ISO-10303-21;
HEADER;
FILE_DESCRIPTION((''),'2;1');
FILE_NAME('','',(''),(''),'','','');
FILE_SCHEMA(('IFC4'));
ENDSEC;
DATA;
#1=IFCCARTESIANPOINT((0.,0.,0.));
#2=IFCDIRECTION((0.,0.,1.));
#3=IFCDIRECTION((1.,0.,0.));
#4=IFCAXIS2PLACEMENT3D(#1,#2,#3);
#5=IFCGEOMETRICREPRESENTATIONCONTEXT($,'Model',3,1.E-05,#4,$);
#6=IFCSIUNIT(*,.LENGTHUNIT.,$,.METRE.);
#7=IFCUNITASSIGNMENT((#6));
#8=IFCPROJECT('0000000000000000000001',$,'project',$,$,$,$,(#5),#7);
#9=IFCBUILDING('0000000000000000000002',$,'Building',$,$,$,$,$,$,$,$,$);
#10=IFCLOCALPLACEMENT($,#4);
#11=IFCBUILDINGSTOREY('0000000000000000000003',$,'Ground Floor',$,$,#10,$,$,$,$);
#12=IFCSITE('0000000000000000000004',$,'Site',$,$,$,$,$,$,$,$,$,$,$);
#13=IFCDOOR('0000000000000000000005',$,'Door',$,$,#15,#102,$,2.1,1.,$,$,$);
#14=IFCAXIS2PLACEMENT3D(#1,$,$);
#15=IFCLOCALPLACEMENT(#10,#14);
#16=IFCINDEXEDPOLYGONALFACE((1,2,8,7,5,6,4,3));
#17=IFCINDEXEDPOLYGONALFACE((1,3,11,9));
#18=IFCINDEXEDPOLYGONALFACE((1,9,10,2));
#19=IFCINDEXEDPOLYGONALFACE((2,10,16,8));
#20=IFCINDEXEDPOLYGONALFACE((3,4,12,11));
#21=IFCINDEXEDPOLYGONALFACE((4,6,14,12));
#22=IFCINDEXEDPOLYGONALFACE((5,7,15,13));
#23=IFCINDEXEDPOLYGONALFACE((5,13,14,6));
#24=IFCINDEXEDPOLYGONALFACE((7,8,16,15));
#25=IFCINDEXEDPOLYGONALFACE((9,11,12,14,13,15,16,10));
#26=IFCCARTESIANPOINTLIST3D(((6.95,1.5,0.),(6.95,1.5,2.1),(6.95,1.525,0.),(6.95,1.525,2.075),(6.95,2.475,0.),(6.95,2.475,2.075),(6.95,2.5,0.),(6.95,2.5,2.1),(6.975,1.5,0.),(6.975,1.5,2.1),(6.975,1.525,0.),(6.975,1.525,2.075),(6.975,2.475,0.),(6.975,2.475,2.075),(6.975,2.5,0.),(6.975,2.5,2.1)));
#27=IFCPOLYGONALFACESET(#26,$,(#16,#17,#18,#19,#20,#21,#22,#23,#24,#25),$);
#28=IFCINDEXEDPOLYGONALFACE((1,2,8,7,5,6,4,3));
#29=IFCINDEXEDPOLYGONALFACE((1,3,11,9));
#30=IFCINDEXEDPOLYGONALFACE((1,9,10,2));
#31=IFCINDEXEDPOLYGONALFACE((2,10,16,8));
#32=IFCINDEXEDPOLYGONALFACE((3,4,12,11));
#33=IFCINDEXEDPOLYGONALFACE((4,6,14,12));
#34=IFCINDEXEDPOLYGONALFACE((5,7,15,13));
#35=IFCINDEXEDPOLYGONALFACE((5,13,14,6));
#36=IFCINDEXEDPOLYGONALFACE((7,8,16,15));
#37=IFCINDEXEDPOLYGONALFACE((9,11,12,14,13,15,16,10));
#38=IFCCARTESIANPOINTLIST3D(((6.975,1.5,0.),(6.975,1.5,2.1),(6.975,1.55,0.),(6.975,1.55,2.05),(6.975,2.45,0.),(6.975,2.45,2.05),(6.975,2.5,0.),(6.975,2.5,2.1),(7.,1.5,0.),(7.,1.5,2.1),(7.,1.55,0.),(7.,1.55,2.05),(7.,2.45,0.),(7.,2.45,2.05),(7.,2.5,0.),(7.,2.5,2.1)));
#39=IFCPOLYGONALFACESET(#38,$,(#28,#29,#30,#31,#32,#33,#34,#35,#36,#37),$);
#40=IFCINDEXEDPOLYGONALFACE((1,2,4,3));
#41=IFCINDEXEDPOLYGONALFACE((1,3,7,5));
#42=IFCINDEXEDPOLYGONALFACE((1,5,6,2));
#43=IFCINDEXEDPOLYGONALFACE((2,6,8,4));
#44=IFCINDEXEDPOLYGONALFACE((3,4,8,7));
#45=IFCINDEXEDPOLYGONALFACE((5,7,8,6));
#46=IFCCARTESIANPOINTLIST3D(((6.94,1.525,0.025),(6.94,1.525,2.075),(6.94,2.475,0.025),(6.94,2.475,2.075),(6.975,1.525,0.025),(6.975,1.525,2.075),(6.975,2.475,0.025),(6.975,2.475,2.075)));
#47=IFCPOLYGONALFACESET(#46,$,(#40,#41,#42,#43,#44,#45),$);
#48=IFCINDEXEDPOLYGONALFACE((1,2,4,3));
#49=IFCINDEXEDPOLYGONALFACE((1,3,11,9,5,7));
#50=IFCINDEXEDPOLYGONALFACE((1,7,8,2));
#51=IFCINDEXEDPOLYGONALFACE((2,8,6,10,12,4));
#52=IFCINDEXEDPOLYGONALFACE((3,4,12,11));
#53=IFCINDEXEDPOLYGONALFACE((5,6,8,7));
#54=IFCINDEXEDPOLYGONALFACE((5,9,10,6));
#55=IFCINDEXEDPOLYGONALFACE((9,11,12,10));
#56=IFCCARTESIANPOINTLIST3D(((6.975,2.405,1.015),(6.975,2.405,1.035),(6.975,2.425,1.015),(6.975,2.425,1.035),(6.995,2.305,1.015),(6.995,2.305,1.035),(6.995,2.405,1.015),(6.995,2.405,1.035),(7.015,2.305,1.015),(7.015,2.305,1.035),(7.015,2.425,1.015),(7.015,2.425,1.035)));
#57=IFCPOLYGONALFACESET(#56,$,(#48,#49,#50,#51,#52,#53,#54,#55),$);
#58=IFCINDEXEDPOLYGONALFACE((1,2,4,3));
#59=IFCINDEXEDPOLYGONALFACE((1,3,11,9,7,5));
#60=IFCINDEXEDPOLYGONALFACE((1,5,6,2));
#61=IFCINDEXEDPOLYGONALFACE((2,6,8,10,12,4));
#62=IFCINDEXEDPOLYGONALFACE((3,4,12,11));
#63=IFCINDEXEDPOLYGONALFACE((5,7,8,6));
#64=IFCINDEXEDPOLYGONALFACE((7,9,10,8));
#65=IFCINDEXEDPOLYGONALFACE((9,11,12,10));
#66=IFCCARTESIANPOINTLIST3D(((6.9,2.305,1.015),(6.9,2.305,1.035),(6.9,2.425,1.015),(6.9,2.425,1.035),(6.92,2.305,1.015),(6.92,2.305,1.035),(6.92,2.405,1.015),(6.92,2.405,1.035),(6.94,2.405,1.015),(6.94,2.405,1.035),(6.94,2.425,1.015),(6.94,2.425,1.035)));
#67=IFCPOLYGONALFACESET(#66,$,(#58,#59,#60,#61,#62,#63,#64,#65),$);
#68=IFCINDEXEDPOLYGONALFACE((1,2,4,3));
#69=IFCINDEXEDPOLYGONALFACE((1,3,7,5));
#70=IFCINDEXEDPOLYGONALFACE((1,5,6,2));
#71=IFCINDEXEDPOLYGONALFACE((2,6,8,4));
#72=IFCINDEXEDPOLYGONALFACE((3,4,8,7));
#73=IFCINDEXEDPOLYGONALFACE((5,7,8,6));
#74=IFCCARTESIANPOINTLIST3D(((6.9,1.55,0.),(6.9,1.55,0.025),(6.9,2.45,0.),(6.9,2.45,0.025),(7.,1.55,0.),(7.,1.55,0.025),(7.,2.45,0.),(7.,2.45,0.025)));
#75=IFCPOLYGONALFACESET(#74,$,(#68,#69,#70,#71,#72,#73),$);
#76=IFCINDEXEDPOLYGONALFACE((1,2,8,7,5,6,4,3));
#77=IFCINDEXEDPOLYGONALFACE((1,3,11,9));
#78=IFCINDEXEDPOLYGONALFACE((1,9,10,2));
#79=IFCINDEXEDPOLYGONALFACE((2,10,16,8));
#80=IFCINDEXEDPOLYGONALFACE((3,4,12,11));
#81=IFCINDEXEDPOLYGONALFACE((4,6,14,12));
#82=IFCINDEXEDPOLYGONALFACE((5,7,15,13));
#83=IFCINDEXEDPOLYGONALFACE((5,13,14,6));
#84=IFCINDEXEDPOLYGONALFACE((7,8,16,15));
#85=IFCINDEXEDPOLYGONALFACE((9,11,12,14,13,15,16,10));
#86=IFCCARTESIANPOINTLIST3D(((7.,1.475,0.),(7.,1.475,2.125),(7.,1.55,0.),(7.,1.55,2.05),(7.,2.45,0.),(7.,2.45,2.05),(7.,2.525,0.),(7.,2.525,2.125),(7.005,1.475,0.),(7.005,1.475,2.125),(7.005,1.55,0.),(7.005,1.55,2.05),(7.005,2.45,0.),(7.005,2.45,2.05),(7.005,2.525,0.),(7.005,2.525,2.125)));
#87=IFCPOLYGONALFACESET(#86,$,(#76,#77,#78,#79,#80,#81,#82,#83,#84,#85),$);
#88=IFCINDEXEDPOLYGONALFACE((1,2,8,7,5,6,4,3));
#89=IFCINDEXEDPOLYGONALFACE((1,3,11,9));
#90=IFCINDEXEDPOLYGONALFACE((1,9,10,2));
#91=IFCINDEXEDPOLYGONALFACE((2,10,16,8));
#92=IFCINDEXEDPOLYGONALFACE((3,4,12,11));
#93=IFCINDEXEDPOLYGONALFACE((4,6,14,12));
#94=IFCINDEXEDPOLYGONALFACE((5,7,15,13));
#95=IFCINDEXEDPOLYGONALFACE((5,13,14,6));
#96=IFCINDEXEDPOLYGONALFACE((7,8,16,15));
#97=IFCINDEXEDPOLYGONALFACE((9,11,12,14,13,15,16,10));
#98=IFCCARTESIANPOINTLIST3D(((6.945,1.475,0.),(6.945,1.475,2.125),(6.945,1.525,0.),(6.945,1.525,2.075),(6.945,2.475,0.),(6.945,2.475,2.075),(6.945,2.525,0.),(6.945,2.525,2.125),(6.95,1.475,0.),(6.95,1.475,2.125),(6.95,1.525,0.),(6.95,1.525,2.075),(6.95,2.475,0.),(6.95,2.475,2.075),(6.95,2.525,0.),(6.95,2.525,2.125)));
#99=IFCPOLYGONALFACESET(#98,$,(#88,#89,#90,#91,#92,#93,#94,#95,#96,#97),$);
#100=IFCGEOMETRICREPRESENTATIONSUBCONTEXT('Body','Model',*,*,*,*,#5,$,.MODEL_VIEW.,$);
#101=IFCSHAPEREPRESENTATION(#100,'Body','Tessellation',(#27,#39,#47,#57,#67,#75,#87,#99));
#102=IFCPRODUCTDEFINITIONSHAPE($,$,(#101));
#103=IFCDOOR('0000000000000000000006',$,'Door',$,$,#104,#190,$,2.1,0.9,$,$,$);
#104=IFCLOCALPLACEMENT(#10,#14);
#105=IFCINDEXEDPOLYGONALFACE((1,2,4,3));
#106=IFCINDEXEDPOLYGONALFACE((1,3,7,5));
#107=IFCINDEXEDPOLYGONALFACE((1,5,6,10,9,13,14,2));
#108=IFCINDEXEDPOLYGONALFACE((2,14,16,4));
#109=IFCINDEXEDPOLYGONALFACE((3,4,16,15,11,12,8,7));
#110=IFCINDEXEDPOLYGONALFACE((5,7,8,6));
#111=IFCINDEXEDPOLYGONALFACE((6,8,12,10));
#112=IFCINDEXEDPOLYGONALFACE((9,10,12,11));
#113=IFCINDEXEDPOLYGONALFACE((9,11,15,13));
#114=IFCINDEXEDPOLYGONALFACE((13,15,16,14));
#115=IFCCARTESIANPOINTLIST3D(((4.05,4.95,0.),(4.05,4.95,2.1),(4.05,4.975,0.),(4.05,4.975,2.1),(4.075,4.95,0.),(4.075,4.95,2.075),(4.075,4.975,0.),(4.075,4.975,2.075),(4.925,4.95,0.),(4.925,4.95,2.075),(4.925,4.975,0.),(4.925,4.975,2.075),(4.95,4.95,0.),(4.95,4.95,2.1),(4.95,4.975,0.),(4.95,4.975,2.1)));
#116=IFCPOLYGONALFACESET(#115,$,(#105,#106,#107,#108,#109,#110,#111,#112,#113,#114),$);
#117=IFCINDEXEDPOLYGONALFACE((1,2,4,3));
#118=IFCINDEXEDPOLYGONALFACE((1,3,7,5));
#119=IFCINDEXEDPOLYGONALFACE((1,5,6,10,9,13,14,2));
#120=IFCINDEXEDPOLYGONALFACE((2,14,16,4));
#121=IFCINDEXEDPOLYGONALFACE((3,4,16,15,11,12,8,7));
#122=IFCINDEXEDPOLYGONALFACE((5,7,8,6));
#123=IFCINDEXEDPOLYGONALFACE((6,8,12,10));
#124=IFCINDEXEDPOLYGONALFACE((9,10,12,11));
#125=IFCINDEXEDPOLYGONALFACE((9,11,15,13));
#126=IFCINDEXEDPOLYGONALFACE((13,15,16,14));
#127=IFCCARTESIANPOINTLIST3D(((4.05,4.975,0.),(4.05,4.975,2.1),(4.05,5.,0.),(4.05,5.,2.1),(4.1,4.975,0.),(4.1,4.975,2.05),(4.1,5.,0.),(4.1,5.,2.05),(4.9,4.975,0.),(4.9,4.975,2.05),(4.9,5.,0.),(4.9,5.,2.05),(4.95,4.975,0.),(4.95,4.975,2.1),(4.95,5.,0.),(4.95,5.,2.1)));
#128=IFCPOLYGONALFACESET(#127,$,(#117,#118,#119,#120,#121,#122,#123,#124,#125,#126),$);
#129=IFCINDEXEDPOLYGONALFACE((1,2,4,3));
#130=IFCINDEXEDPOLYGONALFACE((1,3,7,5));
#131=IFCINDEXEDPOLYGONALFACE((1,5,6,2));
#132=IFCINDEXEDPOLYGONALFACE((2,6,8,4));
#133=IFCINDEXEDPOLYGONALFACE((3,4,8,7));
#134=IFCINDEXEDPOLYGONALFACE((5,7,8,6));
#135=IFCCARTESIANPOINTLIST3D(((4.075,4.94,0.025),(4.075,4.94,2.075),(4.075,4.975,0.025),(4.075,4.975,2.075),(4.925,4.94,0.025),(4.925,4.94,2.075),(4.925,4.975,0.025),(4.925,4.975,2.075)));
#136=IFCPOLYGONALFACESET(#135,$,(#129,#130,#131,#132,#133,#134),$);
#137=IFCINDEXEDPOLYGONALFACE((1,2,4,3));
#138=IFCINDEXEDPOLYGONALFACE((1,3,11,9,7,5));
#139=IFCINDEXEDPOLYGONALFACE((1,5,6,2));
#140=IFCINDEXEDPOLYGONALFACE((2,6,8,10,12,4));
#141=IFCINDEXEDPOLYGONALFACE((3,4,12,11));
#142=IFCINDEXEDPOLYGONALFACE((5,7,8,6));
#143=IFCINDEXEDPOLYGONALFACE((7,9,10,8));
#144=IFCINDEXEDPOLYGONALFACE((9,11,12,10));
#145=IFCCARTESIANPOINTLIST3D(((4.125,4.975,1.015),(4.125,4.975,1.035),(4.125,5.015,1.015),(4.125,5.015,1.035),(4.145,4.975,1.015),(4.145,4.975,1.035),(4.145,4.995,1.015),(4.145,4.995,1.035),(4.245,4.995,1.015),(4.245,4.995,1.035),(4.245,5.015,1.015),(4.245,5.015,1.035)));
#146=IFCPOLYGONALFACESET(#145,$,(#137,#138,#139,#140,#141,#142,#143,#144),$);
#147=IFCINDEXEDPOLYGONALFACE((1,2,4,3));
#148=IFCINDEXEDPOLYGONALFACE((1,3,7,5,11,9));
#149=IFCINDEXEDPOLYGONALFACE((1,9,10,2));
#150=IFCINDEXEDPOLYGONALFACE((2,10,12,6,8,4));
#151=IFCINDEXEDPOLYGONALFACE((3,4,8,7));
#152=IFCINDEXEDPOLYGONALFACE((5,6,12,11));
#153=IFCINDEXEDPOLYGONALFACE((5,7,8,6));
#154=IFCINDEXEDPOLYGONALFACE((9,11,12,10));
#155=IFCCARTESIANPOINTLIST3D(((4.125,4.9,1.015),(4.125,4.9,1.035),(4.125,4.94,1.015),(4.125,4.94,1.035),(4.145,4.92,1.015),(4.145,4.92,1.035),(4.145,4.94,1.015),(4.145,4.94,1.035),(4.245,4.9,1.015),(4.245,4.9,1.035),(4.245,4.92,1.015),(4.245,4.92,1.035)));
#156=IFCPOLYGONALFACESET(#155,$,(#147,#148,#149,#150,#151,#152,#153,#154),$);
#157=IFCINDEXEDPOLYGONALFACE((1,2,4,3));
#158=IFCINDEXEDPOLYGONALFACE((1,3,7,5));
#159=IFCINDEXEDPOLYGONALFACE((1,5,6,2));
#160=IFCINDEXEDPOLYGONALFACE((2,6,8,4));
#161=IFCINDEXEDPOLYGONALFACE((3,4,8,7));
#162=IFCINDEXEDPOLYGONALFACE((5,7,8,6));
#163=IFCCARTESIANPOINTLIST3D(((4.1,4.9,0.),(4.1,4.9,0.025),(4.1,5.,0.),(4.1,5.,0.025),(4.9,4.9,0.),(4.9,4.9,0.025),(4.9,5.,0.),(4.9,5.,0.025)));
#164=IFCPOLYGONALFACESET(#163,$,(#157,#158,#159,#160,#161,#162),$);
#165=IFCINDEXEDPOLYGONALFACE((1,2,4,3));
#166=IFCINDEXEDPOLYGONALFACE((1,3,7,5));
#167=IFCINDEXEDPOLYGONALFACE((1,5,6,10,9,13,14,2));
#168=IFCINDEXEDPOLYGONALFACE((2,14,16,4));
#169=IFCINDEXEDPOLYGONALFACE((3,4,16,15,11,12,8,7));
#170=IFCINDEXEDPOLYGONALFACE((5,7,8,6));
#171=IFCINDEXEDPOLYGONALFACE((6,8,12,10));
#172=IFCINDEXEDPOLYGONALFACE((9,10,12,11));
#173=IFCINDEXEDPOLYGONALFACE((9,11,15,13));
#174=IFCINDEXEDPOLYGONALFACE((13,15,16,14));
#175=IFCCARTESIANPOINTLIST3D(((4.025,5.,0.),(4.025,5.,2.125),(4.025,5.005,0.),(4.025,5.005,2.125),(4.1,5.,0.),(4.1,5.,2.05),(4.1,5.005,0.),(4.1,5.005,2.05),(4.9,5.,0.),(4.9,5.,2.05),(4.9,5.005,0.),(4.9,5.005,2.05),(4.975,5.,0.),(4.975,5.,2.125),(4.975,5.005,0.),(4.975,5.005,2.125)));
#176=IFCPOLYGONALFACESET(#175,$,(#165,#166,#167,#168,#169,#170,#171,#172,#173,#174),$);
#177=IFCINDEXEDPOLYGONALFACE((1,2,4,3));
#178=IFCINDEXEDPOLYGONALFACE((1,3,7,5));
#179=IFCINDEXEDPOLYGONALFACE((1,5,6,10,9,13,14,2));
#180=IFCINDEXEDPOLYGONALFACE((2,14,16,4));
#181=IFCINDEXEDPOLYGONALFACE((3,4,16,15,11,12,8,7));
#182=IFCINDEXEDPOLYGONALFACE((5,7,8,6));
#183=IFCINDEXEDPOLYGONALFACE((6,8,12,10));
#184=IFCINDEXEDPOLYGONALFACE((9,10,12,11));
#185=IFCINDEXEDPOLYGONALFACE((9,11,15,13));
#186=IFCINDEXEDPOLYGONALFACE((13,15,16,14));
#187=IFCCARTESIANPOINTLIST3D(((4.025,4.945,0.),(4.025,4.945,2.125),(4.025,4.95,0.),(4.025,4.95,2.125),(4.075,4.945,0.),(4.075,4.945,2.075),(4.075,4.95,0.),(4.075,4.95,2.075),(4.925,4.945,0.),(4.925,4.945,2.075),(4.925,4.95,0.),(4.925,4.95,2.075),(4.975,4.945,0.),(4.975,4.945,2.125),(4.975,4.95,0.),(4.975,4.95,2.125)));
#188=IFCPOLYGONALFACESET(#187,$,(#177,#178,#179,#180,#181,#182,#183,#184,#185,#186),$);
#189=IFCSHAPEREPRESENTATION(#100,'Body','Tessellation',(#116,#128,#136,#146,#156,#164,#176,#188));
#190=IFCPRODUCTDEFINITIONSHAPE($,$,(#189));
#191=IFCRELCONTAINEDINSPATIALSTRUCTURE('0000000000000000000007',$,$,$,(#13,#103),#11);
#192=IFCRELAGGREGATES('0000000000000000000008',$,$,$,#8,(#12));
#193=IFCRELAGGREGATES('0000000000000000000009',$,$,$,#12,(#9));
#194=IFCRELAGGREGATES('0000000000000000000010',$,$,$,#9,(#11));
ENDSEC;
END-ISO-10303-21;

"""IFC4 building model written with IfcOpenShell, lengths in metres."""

from ifc_helpers import new_model, si_unit, frame, origin_with_axes, place, context, subcontext, project, spatial, line, indexed_curve, outline, extrude, element, save


model = new_model("IFC4")

# Units and contexts
model_context = context("Model", 3, precision=1e-05, world=origin_with_axes())
body_context = subcontext(model_context, "Body", "Model", "MODEL_VIEW")
ifc_project = project(units=[si_unit("LENGTHUNIT", "METRE")], contexts=[model_context])

# Site, building, storey
site = spatial("IfcSite", under=ifc_project, Name="Site")
building = spatial("IfcBuilding", under=site, Name="Building")
storey_placement = place(None, origin_with_axes())
storey = spatial("IfcBuildingStorey", under=building, at=storey_placement, Name="Ground Floor")

# Doors
door_1_placement = place(storey_placement, frame((7.0, 1.5, 0.0), z_axis=(0.0, 0.0, 1.0), x_axis=(0.0, 1.0, 0.0)))
element("IfcDoor", 1, at=door_1_placement, inside=storey, Name="Door", OverallHeight=2.1, OverallWidth=1.0, context=body_context, shape_type="SweptSolid", body=[
    extrude(outline(indexed_curve([(0.0, 0.0), (0.0, 2.1), (1.0, 2.1), (1.0, 0.0), (0.975, 0.0), (0.975, 2.075), (0.025, 2.075), (0.025, 0.0)], segments=[line(1, 2, 3, 4, 5, 6, 7, 8, 1)])), frame((0.0, 0.025, 0.0), z_axis=(0.0, -1.0, 0.0), x_axis=(1.0, 0.0, 0.0)), (0.0, 0.0, -1.0), 0.025),
    extrude(outline(indexed_curve([(0.0, 0.0), (0.0, 2.1), (1.0, 2.1), (1.0, 0.0), (0.95, 0.0), (0.95, 2.05), (0.05, 2.05), (0.05, 0.0)], segments=[line(1, 2, 3, 4, 5, 6, 7, 8, 1)])), frame((0.0, 0.0, 0.0), z_axis=(0.0, -1.0, 0.0), x_axis=(1.0, 0.0, 0.0)), (0.0, 0.0, -1.0), 0.025),
    extrude(outline(indexed_curve([(0.0, 0.0), (0.95, 0.0), (0.95, 0.035), (0.0, 0.035)], segments=[line(1, 2, 3, 4, 1)])), frame((0.025, 0.025, 0.025), z_axis=(0.0, 0.0, 1.0), x_axis=(1.0, 0.0, 0.0)), (0.0, 0.0, 1.0), 2.05),
    extrude(outline(indexed_curve([(0.0, 0.0), (0.0, -0.04), (-0.12, -0.04), (-0.12, -0.02), (-0.02, -0.02), (-0.02, 0.0)], segments=[line(1, 2, 3, 4, 5, 6, 1)])), frame((0.925, 0.025, 1.015), z_axis=(0.0, 0.0, 1.0), x_axis=(1.0, 0.0, 0.0)), (0.0, 0.0, 1.0), 0.02),
    extrude(outline(indexed_curve([(0.0, 0.0), (0.0, 0.04), (-0.12, 0.04), (-0.12, 0.02), (-0.02, 0.02), (-0.02, 0.0)], segments=[line(1, 2, 3, 4, 5, 6, 1)])), frame((0.925, 0.06, 1.015), z_axis=(0.0, 0.0, 1.0), x_axis=(1.0, 0.0, 0.0)), (0.0, 0.0, 1.0), 0.02),
    extrude(outline(indexed_curve([(0.0, 0.0), (0.9, 0.0), (0.9, 0.1), (0.0, 0.1)], segments=[line(1, 2, 3, 4, 1)])), frame((0.05, 0.0, 0.0), z_axis=(0.0, 0.0, 1.0), x_axis=(1.0, 0.0, 0.0)), (0.0, 0.0, 1.0), 0.025),
    extrude(outline(indexed_curve([(0.0, 0.0), (0.0, 2.125), (1.05, 2.125), (1.05, 0.0), (0.975, 0.0), (0.975, 2.05), (0.075, 2.05), (0.075, 0.0)], segments=[line(1, 2, 3, 4, 5, 6, 7, 8, 1)])), frame((-0.025, -0.005, 0.0), z_axis=(0.0, -1.0, 0.0), x_axis=(1.0, 0.0, 0.0)), (0.0, 0.0, -1.0), 0.005),
    extrude(outline(indexed_curve([(0.0, 0.0), (0.0, 2.125), (1.05, 2.125), (1.05, 0.0), (1.0, 0.0), (1.0, 2.075), (0.05, 2.075), (0.05, 0.0)], segments=[line(1, 2, 3, 4, 5, 6, 7, 8, 1)])), frame((-0.025, 0.05, 0.0), z_axis=(0.0, -1.0, 0.0), x_axis=(1.0, 0.0, 0.0)), (0.0, 0.0, -1.0), 0.005),
])
door_2_placement = place(storey_placement, frame((4.95, 5.0, 0.0), z_axis=(0.0, 0.0, 1.0), x_axis=(-1.0, 0.0, 0.0)))
element("IfcDoor", 2, at=door_2_placement, inside=storey, Name="Door", OverallHeight=2.1, OverallWidth=0.9, context=body_context, shape_type="SweptSolid", body=[
    extrude(outline(indexed_curve([(0.0, 0.0), (0.0, 2.1), (0.9, 2.1), (0.9, 0.0), (0.875, 0.0), (0.875, 2.075), (0.025, 2.075), (0.025, 0.0)], segments=[line(1, 2, 3, 4, 5, 6, 7, 8, 1)])), frame((0.0, 0.025, 0.0), z_axis=(0.0, -1.0, 0.0), x_axis=(1.0, 0.0, 0.0)), (0.0, 0.0, -1.0), 0.025),
    extrude(outline(indexed_curve([(0.0, 0.0), (0.0, 2.1), (0.9, 2.1), (0.9, 0.0), (0.85, 0.0), (0.85, 2.05), (0.05, 2.05), (0.05, 0.0)], segments=[line(1, 2, 3, 4, 5, 6, 7, 8, 1)])), frame((0.0, 0.0, 0.0), z_axis=(0.0, -1.0, 0.0), x_axis=(1.0, 0.0, 0.0)), (0.0, 0.0, -1.0), 0.025),
    extrude(outline(indexed_curve([(0.0, 0.0), (0.85, 0.0), (0.85, 0.035), (0.0, 0.035)], segments=[line(1, 2, 3, 4, 1)])), frame((0.025, 0.025, 0.025), z_axis=(0.0, 0.0, 1.0), x_axis=(1.0, 0.0, 0.0)), (0.0, 0.0, 1.0), 2.05),
    extrude(outline(indexed_curve([(0.0, 0.0), (0.0, -0.04), (-0.12, -0.04), (-0.12, -0.02), (-0.02, -0.02), (-0.02, 0.0)], segments=[line(1, 2, 3, 4, 5, 6, 1)])), frame((0.825, 0.025, 1.015), z_axis=(0.0, 0.0, 1.0), x_axis=(1.0, 0.0, 0.0)), (0.0, 0.0, 1.0), 0.02),
    extrude(outline(indexed_curve([(0.0, 0.0), (0.0, 0.04), (-0.12, 0.04), (-0.12, 0.02), (-0.02, 0.02), (-0.02, 0.0)], segments=[line(1, 2, 3, 4, 5, 6, 1)])), frame((0.825, 0.06, 1.015), z_axis=(0.0, 0.0, 1.0), x_axis=(1.0, 0.0, 0.0)), (0.0, 0.0, 1.0), 0.02),
    extrude(outline(indexed_curve([(0.0, 0.0), (0.8, 0.0), (0.8, 0.1), (0.0, 0.1)], segments=[line(1, 2, 3, 4, 1)])), frame((0.05, 0.0, 0.0), z_axis=(0.0, 0.0, 1.0), x_axis=(1.0, 0.0, 0.0)), (0.0, 0.0, 1.0), 0.025),
    extrude(outline(indexed_curve([(0.0, 0.0), (0.0, 2.125), (0.95, 2.125), (0.95, 0.0), (0.875, 0.0), (0.875, 2.05), (0.075, 2.05), (0.075, 0.0)], segments=[line(1, 2, 3, 4, 5, 6, 7, 8, 1)])), frame((-0.025, -0.005, 0.0), z_axis=(0.0, -1.0, 0.0), x_axis=(1.0, 0.0, 0.0)), (0.0, 0.0, -1.0), 0.005),
    extrude(outline(indexed_curve([(0.0, 0.0), (0.0, 2.125), (0.95, 2.125), (0.95, 0.0), (0.9, 0.0), (0.9, 2.075), (0.05, 2.075), (0.05, 0.0)], segments=[line(1, 2, 3, 4, 5, 6, 7, 8, 1)])), frame((-0.025, 0.05, 0.0), z_axis=(0.0, -1.0, 0.0), x_axis=(1.0, 0.0, 0.0)), (0.0, 0.0, -1.0), 0.005),
])

save(model, "model.ifc")
